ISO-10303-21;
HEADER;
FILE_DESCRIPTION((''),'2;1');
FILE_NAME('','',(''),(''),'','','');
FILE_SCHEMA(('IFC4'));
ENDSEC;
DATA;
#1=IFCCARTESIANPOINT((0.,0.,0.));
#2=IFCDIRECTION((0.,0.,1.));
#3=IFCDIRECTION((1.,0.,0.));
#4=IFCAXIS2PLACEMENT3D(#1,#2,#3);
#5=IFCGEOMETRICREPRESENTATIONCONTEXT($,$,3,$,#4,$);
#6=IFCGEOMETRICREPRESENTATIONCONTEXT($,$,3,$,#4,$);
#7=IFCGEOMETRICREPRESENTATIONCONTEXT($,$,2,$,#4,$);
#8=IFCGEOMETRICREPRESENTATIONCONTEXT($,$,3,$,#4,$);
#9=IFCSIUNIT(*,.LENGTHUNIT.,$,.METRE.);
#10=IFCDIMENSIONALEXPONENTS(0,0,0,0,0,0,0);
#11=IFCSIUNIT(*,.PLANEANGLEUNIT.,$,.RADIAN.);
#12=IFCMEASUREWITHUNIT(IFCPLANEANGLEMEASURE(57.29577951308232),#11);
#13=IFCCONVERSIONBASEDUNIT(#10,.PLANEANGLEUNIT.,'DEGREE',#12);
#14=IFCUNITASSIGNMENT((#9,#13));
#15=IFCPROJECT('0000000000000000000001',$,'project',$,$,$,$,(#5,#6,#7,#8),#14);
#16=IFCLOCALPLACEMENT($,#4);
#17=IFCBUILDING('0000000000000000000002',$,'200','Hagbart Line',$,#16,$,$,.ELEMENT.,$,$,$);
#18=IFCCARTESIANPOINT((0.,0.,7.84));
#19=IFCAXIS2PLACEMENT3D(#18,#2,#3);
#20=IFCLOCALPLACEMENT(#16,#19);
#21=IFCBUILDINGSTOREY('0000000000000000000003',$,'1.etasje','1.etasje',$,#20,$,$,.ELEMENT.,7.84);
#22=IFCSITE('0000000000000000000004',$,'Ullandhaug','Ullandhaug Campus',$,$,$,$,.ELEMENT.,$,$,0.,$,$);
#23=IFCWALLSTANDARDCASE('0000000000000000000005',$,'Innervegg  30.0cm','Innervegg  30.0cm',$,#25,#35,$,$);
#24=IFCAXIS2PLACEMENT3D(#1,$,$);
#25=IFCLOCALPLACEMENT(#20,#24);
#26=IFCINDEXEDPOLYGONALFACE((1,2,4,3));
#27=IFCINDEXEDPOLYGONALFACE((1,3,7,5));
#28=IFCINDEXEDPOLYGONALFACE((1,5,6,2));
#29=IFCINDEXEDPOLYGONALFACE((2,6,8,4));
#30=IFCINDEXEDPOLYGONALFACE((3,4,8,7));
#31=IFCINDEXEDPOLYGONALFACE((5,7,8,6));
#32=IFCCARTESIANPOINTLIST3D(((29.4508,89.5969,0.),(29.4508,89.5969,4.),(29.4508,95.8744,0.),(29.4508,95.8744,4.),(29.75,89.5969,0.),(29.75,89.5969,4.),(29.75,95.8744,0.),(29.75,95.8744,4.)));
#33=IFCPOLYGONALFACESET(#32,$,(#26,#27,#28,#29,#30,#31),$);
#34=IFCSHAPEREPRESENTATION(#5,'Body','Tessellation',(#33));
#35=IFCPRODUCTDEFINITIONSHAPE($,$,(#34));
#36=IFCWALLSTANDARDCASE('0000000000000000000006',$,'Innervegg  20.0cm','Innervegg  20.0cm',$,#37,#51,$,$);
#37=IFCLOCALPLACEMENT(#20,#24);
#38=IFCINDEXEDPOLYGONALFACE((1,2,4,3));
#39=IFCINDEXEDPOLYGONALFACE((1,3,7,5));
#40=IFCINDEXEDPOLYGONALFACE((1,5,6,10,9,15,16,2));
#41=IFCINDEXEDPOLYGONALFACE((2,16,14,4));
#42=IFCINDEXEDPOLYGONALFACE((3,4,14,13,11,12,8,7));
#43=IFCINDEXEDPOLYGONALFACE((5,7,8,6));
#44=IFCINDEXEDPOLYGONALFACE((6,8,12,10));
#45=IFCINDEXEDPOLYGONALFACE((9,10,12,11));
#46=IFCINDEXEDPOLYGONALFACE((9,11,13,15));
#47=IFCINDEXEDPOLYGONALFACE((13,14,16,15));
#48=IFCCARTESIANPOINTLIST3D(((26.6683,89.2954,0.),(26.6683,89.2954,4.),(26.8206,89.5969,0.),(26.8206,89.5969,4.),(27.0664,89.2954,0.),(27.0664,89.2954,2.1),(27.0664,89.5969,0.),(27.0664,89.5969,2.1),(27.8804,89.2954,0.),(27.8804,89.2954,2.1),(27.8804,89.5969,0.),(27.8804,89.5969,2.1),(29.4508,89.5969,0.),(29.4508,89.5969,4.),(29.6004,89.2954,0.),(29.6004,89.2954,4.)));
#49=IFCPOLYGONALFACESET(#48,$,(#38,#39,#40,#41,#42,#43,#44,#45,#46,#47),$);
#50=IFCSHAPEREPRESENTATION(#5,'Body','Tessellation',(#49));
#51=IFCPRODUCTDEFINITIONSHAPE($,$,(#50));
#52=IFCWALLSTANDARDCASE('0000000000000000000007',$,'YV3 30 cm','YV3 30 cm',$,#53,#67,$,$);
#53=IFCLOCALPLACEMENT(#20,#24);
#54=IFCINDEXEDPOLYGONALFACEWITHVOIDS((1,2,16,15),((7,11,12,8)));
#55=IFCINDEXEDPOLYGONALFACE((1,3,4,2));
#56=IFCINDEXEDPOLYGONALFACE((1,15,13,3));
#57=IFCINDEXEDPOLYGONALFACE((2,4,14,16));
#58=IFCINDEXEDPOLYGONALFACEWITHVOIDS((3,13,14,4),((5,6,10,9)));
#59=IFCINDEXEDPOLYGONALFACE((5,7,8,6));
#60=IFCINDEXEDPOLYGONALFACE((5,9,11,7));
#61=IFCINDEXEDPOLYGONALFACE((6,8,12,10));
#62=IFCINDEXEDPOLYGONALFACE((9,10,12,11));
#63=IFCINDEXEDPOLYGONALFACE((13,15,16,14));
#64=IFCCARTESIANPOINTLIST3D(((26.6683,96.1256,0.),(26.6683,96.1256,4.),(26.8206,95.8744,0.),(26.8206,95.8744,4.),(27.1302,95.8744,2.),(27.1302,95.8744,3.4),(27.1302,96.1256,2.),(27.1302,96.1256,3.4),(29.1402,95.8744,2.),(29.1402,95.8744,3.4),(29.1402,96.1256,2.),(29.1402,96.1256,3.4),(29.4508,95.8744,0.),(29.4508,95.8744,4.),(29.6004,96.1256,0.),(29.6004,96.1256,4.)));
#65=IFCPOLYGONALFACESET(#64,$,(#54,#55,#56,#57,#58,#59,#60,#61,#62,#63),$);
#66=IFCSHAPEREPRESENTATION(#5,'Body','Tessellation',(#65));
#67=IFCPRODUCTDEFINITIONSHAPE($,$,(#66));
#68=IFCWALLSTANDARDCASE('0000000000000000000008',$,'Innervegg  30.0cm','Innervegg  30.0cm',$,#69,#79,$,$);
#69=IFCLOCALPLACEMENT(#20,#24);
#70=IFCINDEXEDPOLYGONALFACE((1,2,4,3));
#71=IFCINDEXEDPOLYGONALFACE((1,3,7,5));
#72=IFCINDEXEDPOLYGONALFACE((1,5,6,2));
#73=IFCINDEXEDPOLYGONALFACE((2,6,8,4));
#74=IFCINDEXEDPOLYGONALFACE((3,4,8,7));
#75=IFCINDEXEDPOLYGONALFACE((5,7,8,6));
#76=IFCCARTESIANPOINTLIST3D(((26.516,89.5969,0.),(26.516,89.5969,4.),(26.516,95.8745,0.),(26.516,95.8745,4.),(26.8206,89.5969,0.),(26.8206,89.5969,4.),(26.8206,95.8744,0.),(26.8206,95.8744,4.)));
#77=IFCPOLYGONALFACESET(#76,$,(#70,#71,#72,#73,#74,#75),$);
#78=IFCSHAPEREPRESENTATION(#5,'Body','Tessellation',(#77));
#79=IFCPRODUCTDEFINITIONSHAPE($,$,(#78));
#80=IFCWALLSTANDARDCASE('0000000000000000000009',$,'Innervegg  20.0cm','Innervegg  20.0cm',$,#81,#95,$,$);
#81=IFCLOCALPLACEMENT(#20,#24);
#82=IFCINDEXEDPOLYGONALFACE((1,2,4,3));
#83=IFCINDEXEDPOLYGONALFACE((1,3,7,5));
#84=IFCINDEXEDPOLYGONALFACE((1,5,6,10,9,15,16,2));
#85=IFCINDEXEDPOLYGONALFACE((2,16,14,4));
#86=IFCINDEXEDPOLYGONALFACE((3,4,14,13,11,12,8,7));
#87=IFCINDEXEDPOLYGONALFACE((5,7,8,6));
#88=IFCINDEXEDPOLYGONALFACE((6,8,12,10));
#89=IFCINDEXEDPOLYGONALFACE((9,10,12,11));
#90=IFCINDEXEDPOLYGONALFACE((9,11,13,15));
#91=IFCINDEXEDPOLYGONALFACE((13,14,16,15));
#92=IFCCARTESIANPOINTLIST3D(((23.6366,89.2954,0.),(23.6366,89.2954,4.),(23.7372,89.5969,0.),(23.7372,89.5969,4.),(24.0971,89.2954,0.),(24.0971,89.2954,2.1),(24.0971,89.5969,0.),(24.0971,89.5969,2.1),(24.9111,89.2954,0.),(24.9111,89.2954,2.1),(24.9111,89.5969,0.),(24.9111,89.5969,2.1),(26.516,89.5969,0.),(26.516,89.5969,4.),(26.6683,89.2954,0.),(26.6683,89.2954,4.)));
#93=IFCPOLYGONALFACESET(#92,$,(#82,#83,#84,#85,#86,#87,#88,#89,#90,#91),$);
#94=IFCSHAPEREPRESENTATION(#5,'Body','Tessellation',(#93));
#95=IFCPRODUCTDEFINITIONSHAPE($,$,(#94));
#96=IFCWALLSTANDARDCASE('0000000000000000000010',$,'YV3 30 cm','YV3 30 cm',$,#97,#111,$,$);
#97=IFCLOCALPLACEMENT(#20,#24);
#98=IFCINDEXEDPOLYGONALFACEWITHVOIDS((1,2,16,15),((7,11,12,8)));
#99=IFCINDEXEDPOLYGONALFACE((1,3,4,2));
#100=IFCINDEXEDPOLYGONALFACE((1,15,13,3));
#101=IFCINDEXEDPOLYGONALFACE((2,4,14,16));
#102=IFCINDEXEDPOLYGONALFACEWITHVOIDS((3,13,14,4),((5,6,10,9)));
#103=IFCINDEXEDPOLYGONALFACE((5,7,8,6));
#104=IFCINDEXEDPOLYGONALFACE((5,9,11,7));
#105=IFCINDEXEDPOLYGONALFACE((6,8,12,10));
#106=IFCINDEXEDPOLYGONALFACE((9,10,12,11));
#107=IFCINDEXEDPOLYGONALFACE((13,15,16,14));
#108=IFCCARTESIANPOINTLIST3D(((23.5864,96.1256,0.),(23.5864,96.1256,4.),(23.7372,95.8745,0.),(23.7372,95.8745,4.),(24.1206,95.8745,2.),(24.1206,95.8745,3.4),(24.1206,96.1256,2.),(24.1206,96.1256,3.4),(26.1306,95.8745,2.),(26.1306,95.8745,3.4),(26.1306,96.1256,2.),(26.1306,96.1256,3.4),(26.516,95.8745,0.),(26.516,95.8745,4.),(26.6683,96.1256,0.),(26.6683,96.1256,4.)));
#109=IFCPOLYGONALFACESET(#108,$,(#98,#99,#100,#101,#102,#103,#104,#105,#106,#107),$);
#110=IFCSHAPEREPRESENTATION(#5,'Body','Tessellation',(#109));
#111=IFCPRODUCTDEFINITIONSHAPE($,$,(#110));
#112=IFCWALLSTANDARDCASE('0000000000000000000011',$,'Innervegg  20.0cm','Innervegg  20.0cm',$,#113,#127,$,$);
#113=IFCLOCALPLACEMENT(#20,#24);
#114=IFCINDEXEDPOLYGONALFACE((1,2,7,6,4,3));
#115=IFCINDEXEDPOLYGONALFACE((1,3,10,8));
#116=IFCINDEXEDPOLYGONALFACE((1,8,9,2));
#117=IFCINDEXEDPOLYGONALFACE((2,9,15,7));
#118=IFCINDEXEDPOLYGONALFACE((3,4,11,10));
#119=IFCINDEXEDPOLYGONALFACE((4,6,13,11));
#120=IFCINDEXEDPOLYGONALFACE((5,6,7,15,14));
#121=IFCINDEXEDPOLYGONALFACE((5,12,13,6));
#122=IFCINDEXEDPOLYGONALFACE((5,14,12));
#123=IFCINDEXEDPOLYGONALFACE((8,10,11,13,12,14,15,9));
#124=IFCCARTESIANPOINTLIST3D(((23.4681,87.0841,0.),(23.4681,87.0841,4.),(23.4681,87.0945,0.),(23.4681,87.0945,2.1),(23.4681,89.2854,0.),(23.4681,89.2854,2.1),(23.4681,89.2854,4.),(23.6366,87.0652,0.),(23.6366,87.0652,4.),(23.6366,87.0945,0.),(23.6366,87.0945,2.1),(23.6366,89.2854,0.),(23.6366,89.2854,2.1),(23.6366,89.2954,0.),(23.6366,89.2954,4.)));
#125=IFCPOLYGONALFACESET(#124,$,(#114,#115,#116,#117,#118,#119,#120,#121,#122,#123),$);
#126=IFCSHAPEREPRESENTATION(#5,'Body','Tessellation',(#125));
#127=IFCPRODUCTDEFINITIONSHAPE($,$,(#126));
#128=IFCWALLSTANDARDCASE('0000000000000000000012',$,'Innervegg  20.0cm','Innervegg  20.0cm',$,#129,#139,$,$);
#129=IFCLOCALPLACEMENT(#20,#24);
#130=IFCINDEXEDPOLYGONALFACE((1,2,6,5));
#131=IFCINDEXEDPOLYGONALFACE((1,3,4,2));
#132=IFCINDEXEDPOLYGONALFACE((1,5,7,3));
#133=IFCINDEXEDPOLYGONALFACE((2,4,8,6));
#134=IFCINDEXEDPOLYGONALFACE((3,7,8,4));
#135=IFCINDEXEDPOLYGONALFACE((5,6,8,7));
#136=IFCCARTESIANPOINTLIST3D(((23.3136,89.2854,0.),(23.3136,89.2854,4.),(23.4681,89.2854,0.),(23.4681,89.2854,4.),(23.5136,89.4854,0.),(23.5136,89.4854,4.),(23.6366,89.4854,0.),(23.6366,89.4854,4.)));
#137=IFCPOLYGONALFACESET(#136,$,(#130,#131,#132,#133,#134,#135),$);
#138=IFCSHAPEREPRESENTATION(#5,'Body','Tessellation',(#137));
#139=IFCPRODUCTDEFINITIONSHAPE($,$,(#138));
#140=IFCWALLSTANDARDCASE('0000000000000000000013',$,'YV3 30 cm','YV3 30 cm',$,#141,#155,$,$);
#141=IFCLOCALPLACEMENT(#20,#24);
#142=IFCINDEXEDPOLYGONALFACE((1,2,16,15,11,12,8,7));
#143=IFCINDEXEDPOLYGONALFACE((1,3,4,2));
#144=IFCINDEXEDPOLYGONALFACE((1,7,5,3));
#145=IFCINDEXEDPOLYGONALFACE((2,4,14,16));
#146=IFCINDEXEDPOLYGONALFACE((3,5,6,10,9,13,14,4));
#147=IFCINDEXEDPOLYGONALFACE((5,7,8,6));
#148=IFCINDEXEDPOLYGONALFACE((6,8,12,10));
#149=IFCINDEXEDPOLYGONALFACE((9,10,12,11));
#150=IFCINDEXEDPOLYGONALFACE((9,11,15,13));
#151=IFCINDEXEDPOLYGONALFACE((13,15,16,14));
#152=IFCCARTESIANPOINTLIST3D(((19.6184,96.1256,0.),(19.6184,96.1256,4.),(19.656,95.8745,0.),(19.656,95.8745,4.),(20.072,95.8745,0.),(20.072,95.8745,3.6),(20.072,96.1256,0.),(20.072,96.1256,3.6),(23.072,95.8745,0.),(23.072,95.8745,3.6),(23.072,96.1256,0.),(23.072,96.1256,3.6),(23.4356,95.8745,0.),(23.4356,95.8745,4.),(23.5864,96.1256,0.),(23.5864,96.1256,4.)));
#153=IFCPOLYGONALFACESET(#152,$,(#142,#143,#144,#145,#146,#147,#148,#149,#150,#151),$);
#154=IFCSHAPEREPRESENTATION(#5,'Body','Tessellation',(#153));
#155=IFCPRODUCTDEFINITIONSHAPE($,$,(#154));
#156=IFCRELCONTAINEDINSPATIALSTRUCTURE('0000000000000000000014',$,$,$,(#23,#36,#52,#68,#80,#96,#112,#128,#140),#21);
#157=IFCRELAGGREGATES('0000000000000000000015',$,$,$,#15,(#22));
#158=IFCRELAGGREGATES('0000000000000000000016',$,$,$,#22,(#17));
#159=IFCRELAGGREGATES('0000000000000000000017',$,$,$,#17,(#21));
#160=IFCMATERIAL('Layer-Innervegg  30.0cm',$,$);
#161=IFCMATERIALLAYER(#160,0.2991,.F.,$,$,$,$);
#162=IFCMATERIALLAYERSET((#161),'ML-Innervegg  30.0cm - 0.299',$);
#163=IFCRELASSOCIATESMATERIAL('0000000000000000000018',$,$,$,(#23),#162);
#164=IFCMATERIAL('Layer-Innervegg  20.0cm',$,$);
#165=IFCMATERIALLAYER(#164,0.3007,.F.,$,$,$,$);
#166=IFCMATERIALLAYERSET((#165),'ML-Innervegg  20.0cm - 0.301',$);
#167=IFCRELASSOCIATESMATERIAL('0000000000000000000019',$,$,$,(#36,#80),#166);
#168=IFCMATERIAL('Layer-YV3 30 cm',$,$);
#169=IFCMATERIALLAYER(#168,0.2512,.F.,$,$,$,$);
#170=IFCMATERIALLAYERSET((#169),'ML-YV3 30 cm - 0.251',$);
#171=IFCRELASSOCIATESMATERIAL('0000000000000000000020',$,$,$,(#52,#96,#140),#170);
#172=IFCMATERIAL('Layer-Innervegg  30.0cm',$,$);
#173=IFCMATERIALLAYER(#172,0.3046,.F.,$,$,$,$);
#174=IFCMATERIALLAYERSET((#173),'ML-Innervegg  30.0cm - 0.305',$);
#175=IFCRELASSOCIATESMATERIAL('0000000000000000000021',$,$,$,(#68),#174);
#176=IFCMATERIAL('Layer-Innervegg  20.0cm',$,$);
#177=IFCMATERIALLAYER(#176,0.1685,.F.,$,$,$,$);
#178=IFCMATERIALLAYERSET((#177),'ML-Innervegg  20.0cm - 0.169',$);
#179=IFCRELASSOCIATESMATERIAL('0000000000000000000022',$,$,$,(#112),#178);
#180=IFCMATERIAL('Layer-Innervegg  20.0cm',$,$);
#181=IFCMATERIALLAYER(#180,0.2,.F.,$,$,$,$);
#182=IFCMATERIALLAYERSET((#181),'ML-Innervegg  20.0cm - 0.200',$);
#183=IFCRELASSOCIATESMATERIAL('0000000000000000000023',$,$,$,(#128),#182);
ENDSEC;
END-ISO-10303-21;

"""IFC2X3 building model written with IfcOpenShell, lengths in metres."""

from ifc_helpers import new_model, entity, si_unit, converted_unit, frame, origin_with_axes, place, context, project, spatial, polyline, outline, extrude, material, layer, layer_set, layer_usage, element, save


model = new_model("IFC2X3")

# Units and contexts
context_of_model_1 = context(None, 3, world=origin_with_axes())
context_of_model_2 = context(None, 3, world=origin_with_axes())
context_of_model_3 = context(None, 2, world=origin_with_axes())
context_of_model_4 = context(None, 3, world=origin_with_axes())
ifc_project = project(units=[si_unit("LENGTHUNIT", "METRE"), converted_unit("PLANEANGLEUNIT", "DEGREE", entity("IfcPlaneAngleMeasure", 57.29577951308232), si_unit("PLANEANGLEUNIT", "RADIAN"), dimensions=[0, 0, 0, 0, 0, 0, 0])], contexts=[context_of_model_1, context_of_model_2, context_of_model_3, context_of_model_4])

# Site, building, storey
site = spatial("IfcSite", under=ifc_project, Name="Ullandhaug", Description="Ullandhaug Campus", CompositionType="ELEMENT", RefElevation=0.0)
building_placement = place(None, origin_with_axes())
building = spatial("IfcBuilding", under=site, at=building_placement, Name="200", Description="Hagbart Line", CompositionType="ELEMENT")
storey_placement = place(building_placement, frame((0.0, 0.0, 7.84), z_axis=(0.0, 0.0, 1.0), x_axis=(1.0, 0.0, 0.0)))
storey = spatial("IfcBuildingStorey", under=building, at=storey_placement, Name="1.etasje", Description="1.etasje", CompositionType="ELEMENT", Elevation=7.84)

# Shared definitions
ifc_material_1 = material(Name="Layer-Innervegg  20.0cm")
ifc_layer_1 = layer(ifc_material_1, 0.2, ventilated=False)
ifc_layer_set_1 = layer_set([ifc_layer_1], Name="ML-Innervegg  20.0cm - 0.200")
ifc_layer_usage_1 = layer_usage(ifc_layer_set_1, "AXIS2", "POSITIVE", 0.0)

# Shared definitions
ifc_material_2 = material(Name="Layer-Innervegg  20.0cm")
ifc_layer_2 = layer(ifc_material_2, 0.3007, ventilated=False)
ifc_layer_set_2 = layer_set([ifc_layer_2], Name="ML-Innervegg  20.0cm - 0.301")
ifc_layer_usage_2 = layer_usage(ifc_layer_set_2, "AXIS2", "POSITIVE", 0.0)

# Shared definitions
ifc_material_3 = material(Name="Layer-YV3 30 cm")
ifc_layer_3 = layer(ifc_material_3, 0.2512, ventilated=False)
ifc_layer_set_3 = layer_set([ifc_layer_3], Name="ML-YV3 30 cm - 0.251")
ifc_layer_usage_3 = layer_usage(ifc_layer_set_3, "AXIS2", "POSITIVE", 0.0)

# Wall
ifc_material_4 = material(Name="Layer-Innervegg  30.0cm")
ifc_layer_4 = layer(ifc_material_4, 0.2991, ventilated=False)
ifc_layer_set_4 = layer_set([ifc_layer_4], Name="ML-Innervegg  30.0cm - 0.299")
ifc_layer_usage_4 = layer_usage(ifc_layer_set_4, "AXIS2", "POSITIVE", 0.0)
wall_1_placement = place(storey_placement, frame((29.4508, 95.8744, 0.0), z_axis=(0.0, 0.0, 1.0), x_axis=(0.0, -1.0, 0.0)))
element("IfcWallStandardCase", 1, at=wall_1_placement, inside=storey, material=ifc_layer_usage_4, Name="Innervegg  30.0cm", Description="Innervegg  30.0cm", context=context_of_model_1, shape_type="SweptSolid", body=[
    extrude(outline(polyline([(0.0, 0.0), (6.2775, 0.0), (6.2775, 0.2991), (0.0, 0.2991), (0.0, 0.0)])), frame((0.0, 0.0, 0.0), z_axis=(0.0, 0.0, 1.0), x_axis=(1.0, 0.0, 0.0)), (0.0, 0.0, 1.0), 4.0),
])

# Walls, openings
wall_2_placement = place(storey_placement, frame((26.6683, 89.2954, 0.0), z_axis=(0.0, 0.0, 1.0), x_axis=(1.0, 0.0, 0.0)))
wall_2 = element("IfcWallStandardCase", 2, at=wall_2_placement, inside=storey, material=ifc_layer_usage_2, Name="Innervegg  20.0cm", Description="Innervegg  20.0cm", context=context_of_model_1, shape_type="SweptSolid", body=[
    extrude(outline(polyline([(0.0, 0.0), (2.9321, 0.0), (2.7826, 0.3015), (0.1523, 0.3015), (0.0, 0.0)])), origin_with_axes(), (0.0, 0.0, 1.0), 4.0),
])
opening_1_placement = place(wall_2_placement, frame((0.3981, 0.3015, 0.0), z_axis=(0.0, 0.0, 1.0), x_axis=(1.0, 0.0, 0.0)))
element("IfcOpeningElement", 3, at=opening_1_placement, cuts=wall_2, context=context_of_model_1, shape_type="SweptSolid", body=[
    extrude(outline(polyline([(0.0, 0.0), (2.1, 0.0), (2.1, 0.8141), (0.0, 0.8141), (0.0, 0.0)])), frame((0.0, 0.0, 0.0), z_axis=(0.0, 1.0, 0.0), x_axis=(0.0, 0.0, 1.0)), (0.0, 0.0, -1.0), 0.3015),
])
wall_3_placement = place(storey_placement, frame((29.6004, 96.1256, 0.0), z_axis=(0.0, 0.0, 1.0), x_axis=(-1.0, 0.0, 0.0)))
wall_3 = element("IfcWallStandardCase", 4, at=wall_3_placement, inside=storey, material=ifc_layer_usage_3, Name="YV3 30 cm", Description="YV3 30 cm", context=context_of_model_1, shape_type="SweptSolid", body=[
    extrude(outline(polyline([(0.0, 0.0), (2.9321, 0.0), (2.7798, 0.2512), (0.1496, 0.2512), (0.0, 0.0)])), frame((0.0, 0.0, 0.0), z_axis=(0.0, 0.0, 1.0), x_axis=(1.0, 0.0, 0.0)), (0.0, 0.0, 1.0), 4.0),
])
opening_2_placement = place(wall_3_placement, frame((0.4602, 0.2512, 2.0), z_axis=(0.0, 0.0, 1.0), x_axis=(1.0, 0.0, 0.0)))
element("IfcOpeningElement", 5, at=opening_2_placement, cuts=wall_3, context=context_of_model_1, shape_type="SweptSolid", body=[
    extrude(outline(polyline([(0.0, 0.0), (1.4, 0.0), (1.4, 2.01), (0.0, 2.01), (0.0, 0.0)])), frame((0.0, 0.0, 0.0), z_axis=(0.0, 1.0, 0.0), x_axis=(0.0, 0.0, 1.0)), (0.0, 0.0, -1.0), 0.2512),
])

# Wall
ifc_material_5 = material(Name="Layer-Innervegg  30.0cm")
ifc_layer_5 = layer(ifc_material_5, 0.3046, ventilated=False)
ifc_layer_set_5 = layer_set([ifc_layer_5], Name="ML-Innervegg  30.0cm - 0.305")
ifc_layer_usage_5 = layer_usage(ifc_layer_set_5, "AXIS2", "POSITIVE", 0.0)
wall_4_placement = place(storey_placement, frame((26.516, 95.8745, 0.0), z_axis=(0.0, 0.0, 1.0), x_axis=(0.0, -1.0, 0.0)))
element("IfcWallStandardCase", 6, at=wall_4_placement, inside=storey, material=ifc_layer_usage_5, Name="Innervegg  30.0cm", Description="Innervegg  30.0cm", context=context_of_model_1, shape_type="SweptSolid", body=[
    extrude(outline(polyline([(0.0, 0.0), (6.2775, 0.0), (6.2775, 0.3046), (0.0, 0.3046), (0.0, 0.0)])), frame((0.0, 0.0, 0.0), z_axis=(0.0, 0.0, 1.0), x_axis=(1.0, 0.0, 0.0)), (0.0, 0.0, 1.0), 4.0),
])

# Walls, openings
wall_5_placement = place(storey_placement, frame((23.6366, 89.2954, 0.0), z_axis=(0.0, 0.0, 1.0), x_axis=(1.0, 0.0, 0.0)))
wall_5 = element("IfcWallStandardCase", 7, at=wall_5_placement, inside=storey, material=ifc_layer_usage_2, Name="Innervegg  20.0cm", Description="Innervegg  20.0cm", context=context_of_model_1, shape_type="SweptSolid", body=[
    extrude(outline(polyline([(0.0, 0.0), (3.0316, 0.0), (2.8793, 0.3015), (0.1005, 0.3015), (0.0, 0.0)])), origin_with_axes(), (0.0, 0.0, 1.0), 4.0),
])
opening_3_placement = place(wall_5_placement, frame((0.4604, 0.3015, 0.0), z_axis=(0.0, 0.0, 1.0), x_axis=(1.0, 0.0, 0.0)))
element("IfcOpeningElement", 8, at=opening_3_placement, cuts=wall_5, context=context_of_model_1, shape_type="SweptSolid", body=[
    extrude(outline(polyline([(0.0, 0.0), (2.1, 0.0), (2.1, 0.814), (0.0, 0.814), (0.0, 0.0)])), frame((0.0, 0.0, 0.0), z_axis=(0.0, 1.0, 0.0), x_axis=(0.0, 0.0, 1.0)), (0.0, 0.0, -1.0), 0.3015),
])
wall_6_placement = place(storey_placement, frame((26.6683, 96.1256, 0.0), z_axis=(0.0, 0.0, 1.0), x_axis=(-1.0, 0.0, 0.0)))
wall_6 = element("IfcWallStandardCase", 9, at=wall_6_placement, inside=storey, material=ifc_layer_usage_3, Name="YV3 30 cm", Description="YV3 30 cm", context=context_of_model_1, shape_type="SweptSolid", body=[
    extrude(outline(polyline([(0.0, 0.0), (3.0819, 0.0), (2.9311, 0.2512), (0.1523, 0.2512), (0.0, 0.0)])), frame((0.0, 0.0, 0.0), z_axis=(0.0, 0.0, 1.0), x_axis=(1.0, 0.0, 0.0)), (0.0, 0.0, 1.0), 4.0),
])
opening_4_placement = place(wall_6_placement, frame((0.5377, 0.2512, 2.0), z_axis=(0.0, 0.0, 1.0), x_axis=(1.0, 0.0, 0.0)))
element("IfcOpeningElement", 10, at=opening_4_placement, cuts=wall_6, context=context_of_model_1, shape_type="SweptSolid", body=[
    extrude(outline(polyline([(0.0, 0.0), (1.4, 0.0), (1.4, 2.01), (0.0, 2.01), (0.0, 0.0)])), frame((0.0, 0.0, 0.0), z_axis=(0.0, 1.0, 0.0), x_axis=(0.0, 0.0, 1.0)), (0.0, 0.0, -1.0), 0.2512),
])
ifc_material_6 = material(Name="Layer-Innervegg  20.0cm")
ifc_layer_6 = layer(ifc_material_6, 0.1685, ventilated=False)
ifc_layer_set_6 = layer_set([ifc_layer_6], Name="ML-Innervegg  20.0cm - 0.169")
ifc_layer_usage_6 = layer_usage(ifc_layer_set_6, "AXIS2", "POSITIVE", 0.0)
wall_7_placement = place(storey_placement, frame((23.6366, 87.0652, 0.0), z_axis=(0.0, 0.0, 1.0), x_axis=(0.0, 1.0, 0.0)))
wall_7 = element("IfcWallStandardCase", 11, at=wall_7_placement, inside=storey, material=ifc_layer_usage_6, Name="Innervegg  20.0cm", Description="Innervegg  20.0cm", context=context_of_model_1, shape_type="SweptSolid", body=[
    extrude(outline(polyline([(0.0, 0.0), (2.2302, 0.0), (2.2202, 0.1685), (0.0188, 0.1685), (0.0, 0.0)])), frame((0.0, 0.0, 0.0), z_axis=(0.0, 0.0, 1.0), x_axis=(1.0, 0.0, 0.0)), (0.0, 0.0, 1.0), 4.0),
])
opening_5_placement = place(wall_7_placement, frame((0.0293, 0.1685, 0.0), z_axis=(0.0, 0.0, 1.0), x_axis=(1.0, 0.0, 0.0)))
element("IfcOpeningElement", 12, at=opening_5_placement, cuts=wall_7, context=context_of_model_1, shape_type="SweptSolid", body=[
    extrude(outline(polyline([(0.0, 0.0), (2.1, 0.0), (2.1, 2.1909), (0.0, 2.1909), (0.0, 0.0)])), frame((0.0, 0.0, 0.0), z_axis=(0.0, 1.0, 0.0), x_axis=(0.0, 0.0, 1.0)), (0.0, 0.0, -1.0), 0.1685),
])

# Wall
wall_8_placement = place(storey_placement, frame((23.6366, 89.4854, 0.0), z_axis=(0.0, 0.0, 1.0), x_axis=(-1.0, 0.0, 0.0)))
element("IfcWallStandardCase", 13, at=wall_8_placement, inside=storey, material=ifc_layer_usage_1, Name="Innervegg  20.0cm", Description="Innervegg  20.0cm", context=context_of_model_1, shape_type="SweptSolid", body=[
    extrude(outline(polyline([(0.0, 0.0), (0.1231, 0.0), (0.3231, 0.2), (0.1685, 0.2), (0.0, 0.0)])), frame((0.0, 0.0, 0.0), z_axis=(0.0, 0.0, 1.0), x_axis=(1.0, 0.0, 0.0)), (0.0, 0.0, 1.0), 4.0),
])

# Wall, opening
wall_9_placement = place(storey_placement, frame((23.5864, 96.1256, 0.0), z_axis=(0.0, 0.0, 1.0), x_axis=(-1.0, 0.0, 0.0)))
wall_9 = element("IfcWallStandardCase", 14, at=wall_9_placement, inside=storey, material=ifc_layer_usage_3, Name="YV3 30 cm", Description="YV3 30 cm", context=context_of_model_1, shape_type="SweptSolid", body=[
    extrude(outline(polyline([(0.0, 0.0), (3.968, 0.0), (3.9303, 0.2512), (0.1508, 0.2512), (0.0, 0.0)])), frame((0.0, 0.0, 0.0), z_axis=(0.0, 0.0, 1.0), x_axis=(1.0, 0.0, 0.0)), (0.0, 0.0, 1.0), 4.0),
])
opening_6_placement = place(wall_9_placement, frame((0.5144, 0.2512, 0.0), z_axis=(0.0, 0.0, 1.0), x_axis=(1.0, 0.0, 0.0)))
element("IfcOpeningElement", 15, at=opening_6_placement, cuts=wall_9, context=context_of_model_1, shape_type="SweptSolid", body=[
    extrude(outline(polyline([(0.0, 0.0), (3.6, 0.0), (3.6, 3.0), (0.0, 3.0), (0.0, 0.0)])), frame((0.0, 0.0, 0.0), z_axis=(-0.000006, 1.0, 0.0), x_axis=(0.0, 0.0, 1.0)), (0.0, -0.000006, -1.0), 0.2512),
])

save(model, "model.ifc")
